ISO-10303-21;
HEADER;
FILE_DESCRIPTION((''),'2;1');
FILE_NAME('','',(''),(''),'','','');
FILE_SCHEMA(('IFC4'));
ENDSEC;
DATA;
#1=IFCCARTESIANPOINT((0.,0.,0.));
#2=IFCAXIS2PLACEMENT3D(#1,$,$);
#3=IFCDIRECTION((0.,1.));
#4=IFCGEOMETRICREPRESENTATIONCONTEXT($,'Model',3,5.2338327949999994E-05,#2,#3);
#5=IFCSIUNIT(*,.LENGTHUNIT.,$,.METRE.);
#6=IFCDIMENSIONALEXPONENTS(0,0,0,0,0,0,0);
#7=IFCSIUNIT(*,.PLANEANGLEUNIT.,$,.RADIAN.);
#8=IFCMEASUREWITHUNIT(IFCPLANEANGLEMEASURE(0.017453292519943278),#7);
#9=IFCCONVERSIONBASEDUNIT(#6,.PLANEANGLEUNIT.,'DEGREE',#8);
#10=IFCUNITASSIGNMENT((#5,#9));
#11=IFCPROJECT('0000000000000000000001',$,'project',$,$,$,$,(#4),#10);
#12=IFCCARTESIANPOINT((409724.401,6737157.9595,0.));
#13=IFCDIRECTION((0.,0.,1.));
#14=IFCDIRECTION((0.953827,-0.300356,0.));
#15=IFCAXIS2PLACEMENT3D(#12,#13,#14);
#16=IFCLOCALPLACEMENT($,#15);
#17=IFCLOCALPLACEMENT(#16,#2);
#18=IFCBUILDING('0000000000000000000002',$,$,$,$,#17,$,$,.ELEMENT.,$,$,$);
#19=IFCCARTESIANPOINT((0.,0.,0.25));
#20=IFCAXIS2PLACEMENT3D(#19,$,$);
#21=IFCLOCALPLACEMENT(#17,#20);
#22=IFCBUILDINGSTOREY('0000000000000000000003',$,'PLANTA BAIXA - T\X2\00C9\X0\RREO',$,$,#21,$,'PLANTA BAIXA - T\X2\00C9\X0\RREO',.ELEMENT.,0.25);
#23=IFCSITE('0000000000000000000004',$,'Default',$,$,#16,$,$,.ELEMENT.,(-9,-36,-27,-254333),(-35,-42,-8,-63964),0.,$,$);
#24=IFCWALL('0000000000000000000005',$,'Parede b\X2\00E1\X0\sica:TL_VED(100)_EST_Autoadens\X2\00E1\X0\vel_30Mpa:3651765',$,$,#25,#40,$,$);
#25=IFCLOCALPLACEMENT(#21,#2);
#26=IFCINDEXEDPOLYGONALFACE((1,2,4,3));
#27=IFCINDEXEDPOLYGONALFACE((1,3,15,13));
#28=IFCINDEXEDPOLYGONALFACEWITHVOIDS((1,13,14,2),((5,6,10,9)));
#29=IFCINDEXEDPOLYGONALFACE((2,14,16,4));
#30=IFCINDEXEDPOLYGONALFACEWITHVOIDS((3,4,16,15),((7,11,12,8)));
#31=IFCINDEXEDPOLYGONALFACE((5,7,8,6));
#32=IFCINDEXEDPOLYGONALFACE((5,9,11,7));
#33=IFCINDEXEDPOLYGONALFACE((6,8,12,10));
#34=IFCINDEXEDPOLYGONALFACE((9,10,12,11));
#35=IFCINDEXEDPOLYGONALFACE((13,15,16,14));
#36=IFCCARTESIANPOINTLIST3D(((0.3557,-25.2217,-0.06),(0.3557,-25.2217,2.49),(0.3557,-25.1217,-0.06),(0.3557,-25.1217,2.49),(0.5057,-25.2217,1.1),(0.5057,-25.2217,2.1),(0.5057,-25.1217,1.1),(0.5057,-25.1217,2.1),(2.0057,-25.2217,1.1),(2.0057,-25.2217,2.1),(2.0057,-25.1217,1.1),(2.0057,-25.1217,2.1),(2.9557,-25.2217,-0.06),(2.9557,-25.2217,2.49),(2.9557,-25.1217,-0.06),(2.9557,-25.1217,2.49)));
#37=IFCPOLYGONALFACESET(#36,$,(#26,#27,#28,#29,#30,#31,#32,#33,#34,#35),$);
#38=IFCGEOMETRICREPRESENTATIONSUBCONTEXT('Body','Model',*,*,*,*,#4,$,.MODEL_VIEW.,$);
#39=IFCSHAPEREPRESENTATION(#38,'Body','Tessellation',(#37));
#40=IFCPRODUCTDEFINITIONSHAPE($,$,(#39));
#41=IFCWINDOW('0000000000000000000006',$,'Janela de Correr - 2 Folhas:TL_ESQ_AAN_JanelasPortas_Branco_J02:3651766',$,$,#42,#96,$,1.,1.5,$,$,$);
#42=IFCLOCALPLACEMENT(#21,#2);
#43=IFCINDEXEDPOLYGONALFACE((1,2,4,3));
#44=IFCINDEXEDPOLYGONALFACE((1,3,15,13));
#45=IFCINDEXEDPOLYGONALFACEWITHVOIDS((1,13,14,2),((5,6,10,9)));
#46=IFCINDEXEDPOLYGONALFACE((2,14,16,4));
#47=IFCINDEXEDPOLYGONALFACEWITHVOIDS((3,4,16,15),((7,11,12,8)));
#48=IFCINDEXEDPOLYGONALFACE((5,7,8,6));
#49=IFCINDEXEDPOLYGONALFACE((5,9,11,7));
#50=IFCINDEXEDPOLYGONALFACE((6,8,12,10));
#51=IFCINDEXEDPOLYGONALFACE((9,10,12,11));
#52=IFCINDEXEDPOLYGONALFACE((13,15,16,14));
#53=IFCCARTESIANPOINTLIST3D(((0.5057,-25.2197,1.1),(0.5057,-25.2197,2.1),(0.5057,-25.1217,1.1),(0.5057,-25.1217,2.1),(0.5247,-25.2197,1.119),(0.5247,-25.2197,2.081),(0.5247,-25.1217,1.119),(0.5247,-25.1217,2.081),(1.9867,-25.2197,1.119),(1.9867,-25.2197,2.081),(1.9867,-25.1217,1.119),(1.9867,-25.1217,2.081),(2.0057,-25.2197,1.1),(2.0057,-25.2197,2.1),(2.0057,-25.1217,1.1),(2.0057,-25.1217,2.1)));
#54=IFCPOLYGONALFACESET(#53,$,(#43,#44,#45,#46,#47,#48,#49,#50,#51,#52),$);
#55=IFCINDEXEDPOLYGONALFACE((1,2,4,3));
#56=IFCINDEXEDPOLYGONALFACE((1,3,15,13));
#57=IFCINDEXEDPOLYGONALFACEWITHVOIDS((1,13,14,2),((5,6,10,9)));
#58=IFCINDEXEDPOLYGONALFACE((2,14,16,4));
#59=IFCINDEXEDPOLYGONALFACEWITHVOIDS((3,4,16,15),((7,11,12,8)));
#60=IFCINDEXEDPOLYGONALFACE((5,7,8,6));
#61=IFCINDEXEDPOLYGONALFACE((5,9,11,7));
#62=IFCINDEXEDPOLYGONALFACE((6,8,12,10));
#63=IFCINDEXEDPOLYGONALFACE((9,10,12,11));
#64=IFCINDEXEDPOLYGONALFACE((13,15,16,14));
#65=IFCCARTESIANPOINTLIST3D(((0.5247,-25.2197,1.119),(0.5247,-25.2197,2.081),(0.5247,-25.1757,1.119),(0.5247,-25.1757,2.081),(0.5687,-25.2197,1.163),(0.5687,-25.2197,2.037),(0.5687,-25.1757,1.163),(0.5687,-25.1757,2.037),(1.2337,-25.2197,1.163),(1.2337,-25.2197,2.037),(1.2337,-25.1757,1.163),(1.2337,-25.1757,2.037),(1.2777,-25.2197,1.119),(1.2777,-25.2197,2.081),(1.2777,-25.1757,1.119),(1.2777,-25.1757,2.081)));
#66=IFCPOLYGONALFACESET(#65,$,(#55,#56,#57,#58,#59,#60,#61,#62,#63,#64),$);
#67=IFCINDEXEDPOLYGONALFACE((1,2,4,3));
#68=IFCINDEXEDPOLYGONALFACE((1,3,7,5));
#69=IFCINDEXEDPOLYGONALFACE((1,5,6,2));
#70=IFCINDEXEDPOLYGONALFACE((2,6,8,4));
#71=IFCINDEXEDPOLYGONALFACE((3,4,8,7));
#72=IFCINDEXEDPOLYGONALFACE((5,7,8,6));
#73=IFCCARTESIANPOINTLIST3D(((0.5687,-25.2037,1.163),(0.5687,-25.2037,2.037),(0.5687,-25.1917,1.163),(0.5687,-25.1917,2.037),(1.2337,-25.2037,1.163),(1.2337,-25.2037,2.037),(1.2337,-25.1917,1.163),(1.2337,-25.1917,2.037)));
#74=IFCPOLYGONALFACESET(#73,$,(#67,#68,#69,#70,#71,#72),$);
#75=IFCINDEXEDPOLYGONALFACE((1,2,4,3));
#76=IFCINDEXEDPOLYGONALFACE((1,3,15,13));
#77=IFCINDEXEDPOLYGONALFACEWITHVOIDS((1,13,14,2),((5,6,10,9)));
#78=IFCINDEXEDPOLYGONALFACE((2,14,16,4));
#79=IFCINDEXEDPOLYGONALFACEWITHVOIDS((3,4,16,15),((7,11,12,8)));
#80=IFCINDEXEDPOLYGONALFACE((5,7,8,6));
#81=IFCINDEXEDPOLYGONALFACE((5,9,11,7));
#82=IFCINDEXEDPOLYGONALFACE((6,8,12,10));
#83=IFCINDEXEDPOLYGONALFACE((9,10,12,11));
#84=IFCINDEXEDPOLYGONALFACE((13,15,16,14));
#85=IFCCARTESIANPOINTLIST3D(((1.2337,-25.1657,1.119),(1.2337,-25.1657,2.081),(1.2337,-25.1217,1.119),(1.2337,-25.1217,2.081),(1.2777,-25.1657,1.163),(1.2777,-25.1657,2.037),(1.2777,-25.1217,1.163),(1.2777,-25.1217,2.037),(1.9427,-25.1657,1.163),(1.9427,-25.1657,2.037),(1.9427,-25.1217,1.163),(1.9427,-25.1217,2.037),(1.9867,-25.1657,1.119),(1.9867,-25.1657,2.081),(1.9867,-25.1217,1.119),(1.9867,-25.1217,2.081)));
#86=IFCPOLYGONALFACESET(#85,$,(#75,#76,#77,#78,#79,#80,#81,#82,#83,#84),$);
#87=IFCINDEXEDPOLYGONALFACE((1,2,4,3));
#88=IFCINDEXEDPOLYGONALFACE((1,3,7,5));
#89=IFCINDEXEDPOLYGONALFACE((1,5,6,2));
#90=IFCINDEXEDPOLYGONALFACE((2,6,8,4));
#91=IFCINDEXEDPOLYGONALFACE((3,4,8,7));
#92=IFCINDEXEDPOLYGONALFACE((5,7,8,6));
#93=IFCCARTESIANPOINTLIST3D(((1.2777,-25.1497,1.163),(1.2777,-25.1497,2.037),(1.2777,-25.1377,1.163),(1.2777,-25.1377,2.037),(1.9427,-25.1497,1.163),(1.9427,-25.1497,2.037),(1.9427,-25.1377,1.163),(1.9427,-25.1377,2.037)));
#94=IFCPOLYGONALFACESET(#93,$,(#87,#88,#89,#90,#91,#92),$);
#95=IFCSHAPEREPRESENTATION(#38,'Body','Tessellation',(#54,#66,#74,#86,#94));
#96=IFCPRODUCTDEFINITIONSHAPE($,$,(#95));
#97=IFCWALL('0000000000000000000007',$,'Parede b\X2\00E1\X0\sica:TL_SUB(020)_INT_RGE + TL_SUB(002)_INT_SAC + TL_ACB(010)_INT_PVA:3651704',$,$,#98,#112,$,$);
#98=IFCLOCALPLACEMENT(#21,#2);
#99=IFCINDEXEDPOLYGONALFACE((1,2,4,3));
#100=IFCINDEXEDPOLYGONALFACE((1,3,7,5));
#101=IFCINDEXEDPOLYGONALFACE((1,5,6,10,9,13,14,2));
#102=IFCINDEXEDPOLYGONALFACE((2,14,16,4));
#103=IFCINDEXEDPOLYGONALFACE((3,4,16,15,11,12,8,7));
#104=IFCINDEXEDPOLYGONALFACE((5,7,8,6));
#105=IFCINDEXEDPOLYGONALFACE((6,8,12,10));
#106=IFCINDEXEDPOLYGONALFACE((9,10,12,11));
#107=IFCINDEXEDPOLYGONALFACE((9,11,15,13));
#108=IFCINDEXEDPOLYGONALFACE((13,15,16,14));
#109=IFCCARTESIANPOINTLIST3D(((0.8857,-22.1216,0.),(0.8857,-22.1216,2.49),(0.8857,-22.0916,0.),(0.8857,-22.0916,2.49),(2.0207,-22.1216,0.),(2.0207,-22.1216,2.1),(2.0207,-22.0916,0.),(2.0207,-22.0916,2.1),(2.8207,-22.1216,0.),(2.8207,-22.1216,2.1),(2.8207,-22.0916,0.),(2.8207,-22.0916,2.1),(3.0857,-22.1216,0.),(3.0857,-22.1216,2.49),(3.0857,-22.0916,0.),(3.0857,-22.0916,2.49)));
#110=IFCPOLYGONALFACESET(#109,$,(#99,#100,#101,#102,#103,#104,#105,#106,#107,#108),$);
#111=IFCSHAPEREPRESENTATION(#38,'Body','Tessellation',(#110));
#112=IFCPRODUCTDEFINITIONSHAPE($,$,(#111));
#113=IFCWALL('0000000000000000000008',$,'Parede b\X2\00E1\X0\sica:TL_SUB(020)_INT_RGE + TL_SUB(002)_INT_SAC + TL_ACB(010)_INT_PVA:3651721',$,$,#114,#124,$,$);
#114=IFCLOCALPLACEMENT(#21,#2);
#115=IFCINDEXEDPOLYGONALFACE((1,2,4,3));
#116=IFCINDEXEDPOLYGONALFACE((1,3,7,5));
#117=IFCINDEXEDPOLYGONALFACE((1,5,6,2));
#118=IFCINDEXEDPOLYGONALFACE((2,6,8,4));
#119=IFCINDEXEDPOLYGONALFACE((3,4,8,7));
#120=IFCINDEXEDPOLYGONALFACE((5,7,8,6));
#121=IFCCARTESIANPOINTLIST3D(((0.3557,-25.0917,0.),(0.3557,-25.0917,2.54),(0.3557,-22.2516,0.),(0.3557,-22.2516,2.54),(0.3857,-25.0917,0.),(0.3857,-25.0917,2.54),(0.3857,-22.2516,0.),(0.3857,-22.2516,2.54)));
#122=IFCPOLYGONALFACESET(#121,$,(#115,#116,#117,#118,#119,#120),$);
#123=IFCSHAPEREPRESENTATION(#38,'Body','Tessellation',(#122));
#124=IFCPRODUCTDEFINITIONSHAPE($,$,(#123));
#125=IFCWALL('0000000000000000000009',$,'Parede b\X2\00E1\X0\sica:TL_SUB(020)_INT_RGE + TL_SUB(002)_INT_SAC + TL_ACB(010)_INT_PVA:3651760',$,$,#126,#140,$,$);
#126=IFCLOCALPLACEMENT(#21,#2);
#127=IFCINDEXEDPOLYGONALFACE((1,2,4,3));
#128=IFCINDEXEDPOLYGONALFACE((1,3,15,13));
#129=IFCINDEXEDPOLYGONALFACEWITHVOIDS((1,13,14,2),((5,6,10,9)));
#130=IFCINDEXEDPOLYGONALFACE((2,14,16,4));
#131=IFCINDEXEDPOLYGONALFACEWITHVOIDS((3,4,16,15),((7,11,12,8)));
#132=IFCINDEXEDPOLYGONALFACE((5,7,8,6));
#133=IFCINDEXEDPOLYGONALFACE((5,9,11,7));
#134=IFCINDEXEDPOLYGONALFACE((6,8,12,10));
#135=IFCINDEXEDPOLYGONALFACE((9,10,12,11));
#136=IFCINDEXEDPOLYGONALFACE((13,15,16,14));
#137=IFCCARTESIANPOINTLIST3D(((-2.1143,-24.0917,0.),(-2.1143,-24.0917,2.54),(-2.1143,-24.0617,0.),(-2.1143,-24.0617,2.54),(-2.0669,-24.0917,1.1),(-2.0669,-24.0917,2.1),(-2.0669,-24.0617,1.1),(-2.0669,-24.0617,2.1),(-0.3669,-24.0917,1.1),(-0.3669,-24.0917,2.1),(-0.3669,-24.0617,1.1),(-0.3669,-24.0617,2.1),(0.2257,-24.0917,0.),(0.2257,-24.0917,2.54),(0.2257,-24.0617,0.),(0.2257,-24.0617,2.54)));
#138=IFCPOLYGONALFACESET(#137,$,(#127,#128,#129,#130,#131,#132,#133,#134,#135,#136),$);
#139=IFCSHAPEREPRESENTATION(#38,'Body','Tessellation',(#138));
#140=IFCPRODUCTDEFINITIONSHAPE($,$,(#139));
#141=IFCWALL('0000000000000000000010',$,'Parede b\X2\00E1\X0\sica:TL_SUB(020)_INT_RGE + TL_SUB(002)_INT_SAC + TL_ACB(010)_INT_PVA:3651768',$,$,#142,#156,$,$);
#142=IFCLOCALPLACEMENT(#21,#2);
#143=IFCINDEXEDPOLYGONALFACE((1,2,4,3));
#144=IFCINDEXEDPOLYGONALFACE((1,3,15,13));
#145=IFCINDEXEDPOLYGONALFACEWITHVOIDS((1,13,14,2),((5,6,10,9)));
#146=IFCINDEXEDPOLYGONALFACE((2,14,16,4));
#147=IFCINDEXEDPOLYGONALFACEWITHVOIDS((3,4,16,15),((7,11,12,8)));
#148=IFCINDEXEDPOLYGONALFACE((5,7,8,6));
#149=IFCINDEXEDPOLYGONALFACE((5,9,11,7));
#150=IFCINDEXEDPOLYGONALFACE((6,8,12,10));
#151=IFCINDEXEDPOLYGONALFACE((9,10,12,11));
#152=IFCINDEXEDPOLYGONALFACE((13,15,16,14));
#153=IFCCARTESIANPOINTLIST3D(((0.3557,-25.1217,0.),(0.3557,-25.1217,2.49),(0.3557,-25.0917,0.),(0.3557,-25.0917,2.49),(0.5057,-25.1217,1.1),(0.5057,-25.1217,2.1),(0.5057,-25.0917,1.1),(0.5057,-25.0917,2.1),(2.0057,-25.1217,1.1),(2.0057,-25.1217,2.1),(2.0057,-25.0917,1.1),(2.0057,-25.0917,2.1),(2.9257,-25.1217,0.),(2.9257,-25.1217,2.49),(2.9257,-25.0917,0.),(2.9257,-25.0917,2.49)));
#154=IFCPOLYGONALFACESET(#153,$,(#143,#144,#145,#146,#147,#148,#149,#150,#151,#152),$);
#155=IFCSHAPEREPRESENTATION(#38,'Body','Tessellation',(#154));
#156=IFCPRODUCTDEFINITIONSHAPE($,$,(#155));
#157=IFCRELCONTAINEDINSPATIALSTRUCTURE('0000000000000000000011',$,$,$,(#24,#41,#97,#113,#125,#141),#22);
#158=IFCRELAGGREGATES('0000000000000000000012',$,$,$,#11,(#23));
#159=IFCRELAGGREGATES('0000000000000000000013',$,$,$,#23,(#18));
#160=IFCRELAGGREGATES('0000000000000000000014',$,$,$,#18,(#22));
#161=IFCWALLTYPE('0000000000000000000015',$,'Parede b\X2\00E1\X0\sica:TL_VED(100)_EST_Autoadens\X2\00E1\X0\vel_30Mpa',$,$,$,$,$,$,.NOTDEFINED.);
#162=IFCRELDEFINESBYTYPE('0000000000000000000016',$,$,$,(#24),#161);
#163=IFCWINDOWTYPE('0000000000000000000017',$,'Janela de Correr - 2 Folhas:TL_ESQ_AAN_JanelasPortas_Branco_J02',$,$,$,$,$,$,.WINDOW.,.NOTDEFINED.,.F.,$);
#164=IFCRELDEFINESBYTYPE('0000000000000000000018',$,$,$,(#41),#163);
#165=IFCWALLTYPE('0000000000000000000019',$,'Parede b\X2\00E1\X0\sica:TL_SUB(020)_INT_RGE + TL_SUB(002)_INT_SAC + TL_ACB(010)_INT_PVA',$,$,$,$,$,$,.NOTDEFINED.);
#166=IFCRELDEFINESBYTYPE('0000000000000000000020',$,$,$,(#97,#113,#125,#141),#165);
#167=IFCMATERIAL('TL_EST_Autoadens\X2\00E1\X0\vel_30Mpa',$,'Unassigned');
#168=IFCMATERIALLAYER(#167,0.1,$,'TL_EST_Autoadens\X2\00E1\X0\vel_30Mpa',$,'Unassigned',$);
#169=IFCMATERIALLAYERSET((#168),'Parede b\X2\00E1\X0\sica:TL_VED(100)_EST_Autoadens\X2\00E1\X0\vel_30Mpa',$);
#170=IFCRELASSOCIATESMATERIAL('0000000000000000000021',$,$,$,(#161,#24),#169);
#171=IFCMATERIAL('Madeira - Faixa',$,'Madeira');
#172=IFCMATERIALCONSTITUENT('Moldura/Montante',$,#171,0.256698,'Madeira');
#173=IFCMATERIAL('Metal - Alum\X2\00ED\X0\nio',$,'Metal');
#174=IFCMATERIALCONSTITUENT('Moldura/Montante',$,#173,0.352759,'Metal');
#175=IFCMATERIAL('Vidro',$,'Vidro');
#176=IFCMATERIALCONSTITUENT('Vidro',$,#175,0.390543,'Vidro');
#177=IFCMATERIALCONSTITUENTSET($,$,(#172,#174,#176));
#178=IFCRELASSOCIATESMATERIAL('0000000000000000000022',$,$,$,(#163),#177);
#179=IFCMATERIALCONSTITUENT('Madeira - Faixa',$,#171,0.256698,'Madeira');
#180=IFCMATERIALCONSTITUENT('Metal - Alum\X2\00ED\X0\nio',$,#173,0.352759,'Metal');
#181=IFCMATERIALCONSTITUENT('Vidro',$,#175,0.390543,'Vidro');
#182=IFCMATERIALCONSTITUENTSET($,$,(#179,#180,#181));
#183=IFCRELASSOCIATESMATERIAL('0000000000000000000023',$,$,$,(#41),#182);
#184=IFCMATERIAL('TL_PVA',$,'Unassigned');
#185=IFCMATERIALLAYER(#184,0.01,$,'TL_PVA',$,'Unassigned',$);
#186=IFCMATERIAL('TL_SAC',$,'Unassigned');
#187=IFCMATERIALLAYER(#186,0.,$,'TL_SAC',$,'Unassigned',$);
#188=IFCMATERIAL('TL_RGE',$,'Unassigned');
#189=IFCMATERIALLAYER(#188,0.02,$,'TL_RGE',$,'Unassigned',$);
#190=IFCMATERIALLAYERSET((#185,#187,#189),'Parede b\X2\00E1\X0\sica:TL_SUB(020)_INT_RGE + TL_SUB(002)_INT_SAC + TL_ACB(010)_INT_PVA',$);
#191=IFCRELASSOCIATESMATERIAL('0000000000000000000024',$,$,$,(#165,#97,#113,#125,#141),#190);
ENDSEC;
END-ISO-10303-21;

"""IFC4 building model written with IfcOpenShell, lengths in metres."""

from ifc_helpers import new_model, entity, si_unit, converted_unit, direction, frame, frame_2d, origin, origin_2d_with_axis, place, context, subcontext, project, spatial, polyline, rectangle, outline, extrude, source, transform, mapped, material, layer, layer_set, layer_usage, constituent, constituent_set, type_object, type_shapes, element, fill, save


model = new_model("IFC4")

# Units and contexts
model_context = context("Model", 3, precision=5.2338327949999994e-05, world=origin(), true_north=direction((0.0, 1.0)))
body_context = subcontext(model_context, "Body", "Model", "MODEL_VIEW")
ifc_project = project(units=[si_unit("LENGTHUNIT", "METRE"), converted_unit("PLANEANGLEUNIT", "DEGREE", entity("IfcPlaneAngleMeasure", 0.017453292519943278), si_unit("PLANEANGLEUNIT", "RADIAN"), dimensions=[0, 0, 0, 0, 0, 0, 0])], contexts=[model_context])

# Site, building, storey
site_placement = place(None, frame((409724.401, 6737157.9595, 0.0), z_axis=(0.0, 0.0, 1.0), x_axis=(0.953827, -0.300356, 0.0)))
site = spatial("IfcSite", under=ifc_project, at=site_placement, Name="Default", CompositionType="ELEMENT", RefLatitude=(-9, -36, -27, -254333), RefLongitude=(-35, -42, -8, -63964), RefElevation=0.0)
building_placement = place(site_placement, origin())
building = spatial("IfcBuilding", under=site, at=building_placement, CompositionType="ELEMENT")
storey_placement = place(building_placement, frame((0.0, 0.0, 0.25)))
storey = spatial("IfcBuildingStorey", under=building, at=storey_placement, Name="PLANTA BAIXA - TÉRREO", LongName="PLANTA BAIXA - TÉRREO", CompositionType="ELEMENT", Elevation=0.25)

# Shared definitions
ifc_material_1 = material(Name="TL_EST_Autoadensável_30Mpa", Category="Unassigned")
ifc_layer_1 = layer(ifc_material_1, 0.1, Name="TL_EST_Autoadensável_30Mpa", Category="Unassigned")
ifc_layer_set_1 = layer_set([ifc_layer_1], Name="Parede básica:TL_VED(100)_EST_Autoadensável_30Mpa")
wall_type_1 = type_object("IfcWallType", Name="Parede básica:TL_VED(100)_EST_Autoadensável_30Mpa", PredefinedType="NOTDEFINED", material=ifc_layer_set_1)

# Shared definitions
ifc_material_2 = material(Name="Vidro", Category="Vidro")

# Wall, opening, window
ifc_layer_usage_1 = layer_usage(ifc_layer_set_1, "AXIS2", "POSITIVE", -0.05)
wall_1_placement = place(storey_placement, frame((0.3557, -25.1717, -0.06)))
wall_1 = element("IfcWall", 1, at=wall_1_placement, inside=storey, type_object=wall_type_1, material=ifc_layer_usage_1, Name="Parede básica:TL_VED(100)_EST_Autoadensável_30Mpa:3651765", context=body_context, shape_type="SweptSolid", body=[
    extrude(rectangle(XDim=2.6, YDim=0.1, at=frame_2d((1.3, 0.0), x_axis=(-1.0, 0.0))), origin(), (0.0, 0.0, 1.0), 2.55),
])
opening_1_placement = place(wall_1_placement, frame((1.65, 0.05, 1.16)))
opening_1 = element("IfcOpeningElement", 2, at=opening_1_placement, cuts=wall_1, PredefinedType="OPENING", context=body_context, shape_type="SweptSolid", body=[
    extrude(rectangle(XDim=1.0, YDim=1.5, at=frame_2d((0.5, 0.75), x_axis=(-1.0, 0.0))), frame((0.0, 0.0, 0.0), z_axis=(0.0, -1.0, 0.0), x_axis=(0.0, 0.0, 1.0)), (0.0, 0.0, 1.0), 0.1),
])
ifc_material_3 = material(Name="Madeira - Faixa", Category="Madeira")
ifc_constituent_1 = constituent(ifc_material_3, Name="Madeira - Faixa", Category="Madeira", fraction=0.256698)
ifc_material_4 = material(Name="Metal - Alumínio", Category="Metal")
ifc_constituent_2 = constituent(ifc_material_4, Name="Metal - Alumínio", Category="Metal", fraction=0.352759)
ifc_constituent_3 = constituent(ifc_material_2, Name="Vidro", Category="Vidro", fraction=0.390543)
ifc_constituent_set_1 = constituent_set(constituents=[ifc_constituent_1, ifc_constituent_2, ifc_constituent_3])
ifc_constituent_4 = constituent(ifc_material_3, Name="Moldura/Montante", Category="Madeira", fraction=0.256698)
ifc_constituent_5 = constituent(ifc_material_4, Name="Moldura/Montante", Category="Metal", fraction=0.352759)
ifc_constituent_6 = constituent(ifc_material_2, Name="Vidro", Category="Vidro", fraction=0.390543)
ifc_constituent_set_2 = constituent_set(constituents=[ifc_constituent_4, ifc_constituent_5, ifc_constituent_6])
window_type = type_object("IfcWindowType", Name="Janela de Correr - 2 Folhas:TL_ESQ_AAN_JanelasPortas_Branco_J02", ParameterTakesPrecedence=False, PartitioningType="NOTDEFINED", PredefinedType="WINDOW", material=ifc_constituent_set_2)
shared_shape_1 = source(origin(), body_context, "Body", "SweptSolid", [
    extrude(outline(polyline([(-0.75, -0.5), (0.75, -0.5), (0.75, 0.5), (-0.75, 0.5), (-0.75, -0.5)]), holes=[polyline([(-0.731, -0.481), (-0.731, 0.481), (0.731, 0.481), (0.731, -0.481), (-0.731, -0.481)])]), frame((0.75, 0.0, 0.5), z_axis=(0.0, 1.0, 0.0), x_axis=(1.0, 0.0, 0.0)), (0.0, 0.0, 1.0), 0.098),
    extrude(outline(polyline([(-0.3765, -0.481), (0.3765, -0.481), (0.3765, 0.481), (-0.3765, 0.481), (-0.3765, -0.481)]), holes=[polyline([(-0.3325, -0.437), (-0.3325, 0.437), (0.3325, 0.437), (0.3325, -0.437), (-0.3325, -0.437)])]), frame((1.1045, 0.054, 0.5), z_axis=(0.0, 1.0, 0.0), x_axis=(1.0, 0.0, 0.0)), (0.0, 0.0, 1.0), 0.044),
    extrude(rectangle(XDim=0.012, YDim=0.665, at=origin_2d_with_axis()), frame((1.1045, 0.076, 0.063), z_axis=(0.0, 0.0, 1.0), x_axis=(0.0, -1.0, 0.0)), (0.0, 0.0, 1.0), 0.874),
    extrude(outline(polyline([(-0.481, -0.3765), (0.481, -0.3765), (0.481, 0.3765), (-0.481, 0.3765), (-0.481, -0.3765)]), holes=[polyline([(-0.437, -0.3325), (-0.437, 0.3325), (0.437, 0.3325), (0.437, -0.3325), (-0.437, -0.3325)])]), frame((0.3955, 0.0, 0.5), z_axis=(0.0, 1.0, 0.0), x_axis=(0.0, 0.0, -1.0)), (0.0, 0.0, 1.0), 0.044),
    extrude(rectangle(XDim=0.012, YDim=0.665, at=origin_2d_with_axis()), frame((0.3955, 0.022, 0.063), z_axis=(0.0, 0.0, 1.0), x_axis=(0.0, -1.0, 0.0)), (0.0, 0.0, 1.0), 0.874),
])
type_shapes(window_type, [shared_shape_1])
window_placement = place(opening_1_placement, frame((0.0, 0.0, 0.0), z_axis=(0.0, 0.0, 1.0), x_axis=(-1.0, 0.0, 0.0)))
window = element("IfcWindow", 3, at=window_placement, inside=storey, type_object=window_type, material=ifc_constituent_set_1, Name="Janela de Correr - 2 Folhas:TL_ESQ_AAN_JanelasPortas_Branco_J02:3651766", OverallHeight=1.0, OverallWidth=1.5, context=body_context, shape_type="MappedRepresentation", body=[
    mapped(shared_shape_1, transform((0.0, 0.0, 0.0), scale=1.0)),
])
fill(opening_1, window)

# Wall, opening
ifc_material_5 = material(Name="TL_PVA", Category="Unassigned")
ifc_layer_2 = layer(ifc_material_5, 0.01, Name="TL_PVA", Category="Unassigned")
ifc_material_6 = material(Name="TL_SAC", Category="Unassigned")
ifc_layer_3 = layer(ifc_material_6, 0.0, Name="TL_SAC", Category="Unassigned")
ifc_material_7 = material(Name="TL_RGE", Category="Unassigned")
ifc_layer_4 = layer(ifc_material_7, 0.02, Name="TL_RGE", Category="Unassigned")
ifc_layer_set_2 = layer_set([ifc_layer_2, ifc_layer_3, ifc_layer_4], Name="Parede básica:TL_SUB(020)_INT_RGE + TL_SUB(002)_INT_SAC + TL_ACB(010)_INT_PVA")
ifc_layer_usage_2 = layer_usage(ifc_layer_set_2, "AXIS2", "NEGATIVE", 0.015)
wall_type_2 = type_object("IfcWallType", Name="Parede básica:TL_SUB(020)_INT_RGE + TL_SUB(002)_INT_SAC + TL_ACB(010)_INT_PVA", PredefinedType="NOTDEFINED", material=ifc_layer_set_2)
wall_2_placement = place(storey_placement, frame((0.8857, -22.1066, 0.0)))
wall_2 = element("IfcWall", 4, at=wall_2_placement, inside=storey, type_object=wall_type_2, material=ifc_layer_usage_2, Name="Parede básica:TL_SUB(020)_INT_RGE + TL_SUB(002)_INT_SAC + TL_ACB(010)_INT_PVA:3651704", context=body_context, shape_type="SweptSolid", body=[
    extrude(rectangle(XDim=2.2, YDim=0.03, at=frame_2d((1.1, 0.0), x_axis=(1.0, 0.0))), origin(), (0.0, 0.0, 1.0), 2.49),
])
opening_2_placement = place(wall_2_placement, frame((-0.8857, 22.1066, 0.0)))
element("IfcOpeningElement", 5, at=opening_2_placement, cuts=wall_2, PredefinedType="OPENING", context=body_context, shape_type="SweptSolid", body=[
    extrude(rectangle(XDim=2.1, YDim=0.8, at=frame_2d((0.0, 0.0), x_axis=(0.0, 1.0))), frame((2.4207, -23.6456, 1.05), z_axis=(0.0, 1.0, 0.0), x_axis=(-1.0, 0.0, 0.0)), (0.0, 0.0, 1.0), 3.048),
])

# Wall
ifc_layer_usage_3 = layer_usage(ifc_layer_set_2, "AXIS2", "POSITIVE", -0.015)
wall_3_placement = place(storey_placement, frame((0.3707, -25.0917, 0.0), z_axis=(0.0, 0.0, 1.0), x_axis=(0.0, 1.0, 0.0)))
element("IfcWall", 6, at=wall_3_placement, inside=storey, type_object=wall_type_2, material=ifc_layer_usage_3, Name="Parede básica:TL_SUB(020)_INT_RGE + TL_SUB(002)_INT_SAC + TL_ACB(010)_INT_PVA:3651721", context=body_context, shape_type="SweptSolid", body=[
    extrude(rectangle(XDim=2.8401, YDim=0.03, at=frame_2d((1.4201, 0.0), x_axis=(-1.0, 0.0))), origin(), (0.0, 0.0, 1.0), 2.54),
])

# Walls, openings
ifc_layer_usage_4 = layer_usage(ifc_layer_set_2, "AXIS2", "POSITIVE", -0.015)
wall_4_placement = place(storey_placement, frame((0.2257, -24.0767, 0.0), z_axis=(0.0, 0.0, 1.0), x_axis=(-1.0, 0.0, 0.0)))
wall_4 = element("IfcWall", 7, at=wall_4_placement, inside=storey, type_object=wall_type_2, material=ifc_layer_usage_4, Name="Parede básica:TL_SUB(020)_INT_RGE + TL_SUB(002)_INT_SAC + TL_ACB(010)_INT_PVA:3651760", context=body_context, shape_type="SweptSolid", body=[
    extrude(rectangle(XDim=2.34, YDim=0.03, at=frame_2d((1.17, 0.0), x_axis=(-1.0, 0.0))), origin(), (0.0, 0.0, 1.0), 2.54),
])
opening_3_placement = place(wall_4_placement, frame((0.2257, -24.0767, 1.1)))
element("IfcOpeningElement", 8, at=opening_3_placement, cuts=wall_4, PredefinedType="OPENING", context=body_context, shape_type="SweptSolid", body=[
    extrude(rectangle(XDim=1.0, YDim=1.7, at=frame_2d((0.0, 0.0), x_axis=(0.0, 1.0))), frame((1.2169, 22.5677, 0.5), z_axis=(0.0, 1.0, 0.0), x_axis=(1.0, 0.0, 0.0)), (0.0, 0.0, 1.0), 3.048),
])
ifc_layer_usage_5 = layer_usage(ifc_layer_set_2, "AXIS2", "POSITIVE", -0.015)
wall_5_placement = place(storey_placement, frame((2.9257, -25.1067, 0.0), z_axis=(0.0, 0.0, 1.0), x_axis=(-1.0, 0.0, 0.0)))
wall_5 = element("IfcWall", 9, at=wall_5_placement, inside=storey, type_object=wall_type_2, material=ifc_layer_usage_5, Name="Parede básica:TL_SUB(020)_INT_RGE + TL_SUB(002)_INT_SAC + TL_ACB(010)_INT_PVA:3651768", context=body_context, shape_type="SweptSolid", body=[
    extrude(rectangle(XDim=2.57, YDim=0.03, at=frame_2d((1.285, 0.0), x_axis=(-1.0, 0.0))), origin(), (0.0, 0.0, 1.0), 2.49),
])
opening_4_placement = place(wall_5_placement, frame((2.9257, -25.1067, 1.1)))
element("IfcOpeningElement", 10, at=opening_4_placement, cuts=wall_5, PredefinedType="OPENING", context=body_context, shape_type="SweptSolid", body=[
    extrude(rectangle(XDim=1.0, YDim=1.5, at=frame_2d((0.0, 0.0), x_axis=(0.0, 1.0))), frame((-1.2557, 23.5977, 0.5), z_axis=(0.0, 1.0, 0.0), x_axis=(1.0, 0.0, 0.0)), (0.0, 0.0, 1.0), 3.048),
])

save(model, "model.ifc")
